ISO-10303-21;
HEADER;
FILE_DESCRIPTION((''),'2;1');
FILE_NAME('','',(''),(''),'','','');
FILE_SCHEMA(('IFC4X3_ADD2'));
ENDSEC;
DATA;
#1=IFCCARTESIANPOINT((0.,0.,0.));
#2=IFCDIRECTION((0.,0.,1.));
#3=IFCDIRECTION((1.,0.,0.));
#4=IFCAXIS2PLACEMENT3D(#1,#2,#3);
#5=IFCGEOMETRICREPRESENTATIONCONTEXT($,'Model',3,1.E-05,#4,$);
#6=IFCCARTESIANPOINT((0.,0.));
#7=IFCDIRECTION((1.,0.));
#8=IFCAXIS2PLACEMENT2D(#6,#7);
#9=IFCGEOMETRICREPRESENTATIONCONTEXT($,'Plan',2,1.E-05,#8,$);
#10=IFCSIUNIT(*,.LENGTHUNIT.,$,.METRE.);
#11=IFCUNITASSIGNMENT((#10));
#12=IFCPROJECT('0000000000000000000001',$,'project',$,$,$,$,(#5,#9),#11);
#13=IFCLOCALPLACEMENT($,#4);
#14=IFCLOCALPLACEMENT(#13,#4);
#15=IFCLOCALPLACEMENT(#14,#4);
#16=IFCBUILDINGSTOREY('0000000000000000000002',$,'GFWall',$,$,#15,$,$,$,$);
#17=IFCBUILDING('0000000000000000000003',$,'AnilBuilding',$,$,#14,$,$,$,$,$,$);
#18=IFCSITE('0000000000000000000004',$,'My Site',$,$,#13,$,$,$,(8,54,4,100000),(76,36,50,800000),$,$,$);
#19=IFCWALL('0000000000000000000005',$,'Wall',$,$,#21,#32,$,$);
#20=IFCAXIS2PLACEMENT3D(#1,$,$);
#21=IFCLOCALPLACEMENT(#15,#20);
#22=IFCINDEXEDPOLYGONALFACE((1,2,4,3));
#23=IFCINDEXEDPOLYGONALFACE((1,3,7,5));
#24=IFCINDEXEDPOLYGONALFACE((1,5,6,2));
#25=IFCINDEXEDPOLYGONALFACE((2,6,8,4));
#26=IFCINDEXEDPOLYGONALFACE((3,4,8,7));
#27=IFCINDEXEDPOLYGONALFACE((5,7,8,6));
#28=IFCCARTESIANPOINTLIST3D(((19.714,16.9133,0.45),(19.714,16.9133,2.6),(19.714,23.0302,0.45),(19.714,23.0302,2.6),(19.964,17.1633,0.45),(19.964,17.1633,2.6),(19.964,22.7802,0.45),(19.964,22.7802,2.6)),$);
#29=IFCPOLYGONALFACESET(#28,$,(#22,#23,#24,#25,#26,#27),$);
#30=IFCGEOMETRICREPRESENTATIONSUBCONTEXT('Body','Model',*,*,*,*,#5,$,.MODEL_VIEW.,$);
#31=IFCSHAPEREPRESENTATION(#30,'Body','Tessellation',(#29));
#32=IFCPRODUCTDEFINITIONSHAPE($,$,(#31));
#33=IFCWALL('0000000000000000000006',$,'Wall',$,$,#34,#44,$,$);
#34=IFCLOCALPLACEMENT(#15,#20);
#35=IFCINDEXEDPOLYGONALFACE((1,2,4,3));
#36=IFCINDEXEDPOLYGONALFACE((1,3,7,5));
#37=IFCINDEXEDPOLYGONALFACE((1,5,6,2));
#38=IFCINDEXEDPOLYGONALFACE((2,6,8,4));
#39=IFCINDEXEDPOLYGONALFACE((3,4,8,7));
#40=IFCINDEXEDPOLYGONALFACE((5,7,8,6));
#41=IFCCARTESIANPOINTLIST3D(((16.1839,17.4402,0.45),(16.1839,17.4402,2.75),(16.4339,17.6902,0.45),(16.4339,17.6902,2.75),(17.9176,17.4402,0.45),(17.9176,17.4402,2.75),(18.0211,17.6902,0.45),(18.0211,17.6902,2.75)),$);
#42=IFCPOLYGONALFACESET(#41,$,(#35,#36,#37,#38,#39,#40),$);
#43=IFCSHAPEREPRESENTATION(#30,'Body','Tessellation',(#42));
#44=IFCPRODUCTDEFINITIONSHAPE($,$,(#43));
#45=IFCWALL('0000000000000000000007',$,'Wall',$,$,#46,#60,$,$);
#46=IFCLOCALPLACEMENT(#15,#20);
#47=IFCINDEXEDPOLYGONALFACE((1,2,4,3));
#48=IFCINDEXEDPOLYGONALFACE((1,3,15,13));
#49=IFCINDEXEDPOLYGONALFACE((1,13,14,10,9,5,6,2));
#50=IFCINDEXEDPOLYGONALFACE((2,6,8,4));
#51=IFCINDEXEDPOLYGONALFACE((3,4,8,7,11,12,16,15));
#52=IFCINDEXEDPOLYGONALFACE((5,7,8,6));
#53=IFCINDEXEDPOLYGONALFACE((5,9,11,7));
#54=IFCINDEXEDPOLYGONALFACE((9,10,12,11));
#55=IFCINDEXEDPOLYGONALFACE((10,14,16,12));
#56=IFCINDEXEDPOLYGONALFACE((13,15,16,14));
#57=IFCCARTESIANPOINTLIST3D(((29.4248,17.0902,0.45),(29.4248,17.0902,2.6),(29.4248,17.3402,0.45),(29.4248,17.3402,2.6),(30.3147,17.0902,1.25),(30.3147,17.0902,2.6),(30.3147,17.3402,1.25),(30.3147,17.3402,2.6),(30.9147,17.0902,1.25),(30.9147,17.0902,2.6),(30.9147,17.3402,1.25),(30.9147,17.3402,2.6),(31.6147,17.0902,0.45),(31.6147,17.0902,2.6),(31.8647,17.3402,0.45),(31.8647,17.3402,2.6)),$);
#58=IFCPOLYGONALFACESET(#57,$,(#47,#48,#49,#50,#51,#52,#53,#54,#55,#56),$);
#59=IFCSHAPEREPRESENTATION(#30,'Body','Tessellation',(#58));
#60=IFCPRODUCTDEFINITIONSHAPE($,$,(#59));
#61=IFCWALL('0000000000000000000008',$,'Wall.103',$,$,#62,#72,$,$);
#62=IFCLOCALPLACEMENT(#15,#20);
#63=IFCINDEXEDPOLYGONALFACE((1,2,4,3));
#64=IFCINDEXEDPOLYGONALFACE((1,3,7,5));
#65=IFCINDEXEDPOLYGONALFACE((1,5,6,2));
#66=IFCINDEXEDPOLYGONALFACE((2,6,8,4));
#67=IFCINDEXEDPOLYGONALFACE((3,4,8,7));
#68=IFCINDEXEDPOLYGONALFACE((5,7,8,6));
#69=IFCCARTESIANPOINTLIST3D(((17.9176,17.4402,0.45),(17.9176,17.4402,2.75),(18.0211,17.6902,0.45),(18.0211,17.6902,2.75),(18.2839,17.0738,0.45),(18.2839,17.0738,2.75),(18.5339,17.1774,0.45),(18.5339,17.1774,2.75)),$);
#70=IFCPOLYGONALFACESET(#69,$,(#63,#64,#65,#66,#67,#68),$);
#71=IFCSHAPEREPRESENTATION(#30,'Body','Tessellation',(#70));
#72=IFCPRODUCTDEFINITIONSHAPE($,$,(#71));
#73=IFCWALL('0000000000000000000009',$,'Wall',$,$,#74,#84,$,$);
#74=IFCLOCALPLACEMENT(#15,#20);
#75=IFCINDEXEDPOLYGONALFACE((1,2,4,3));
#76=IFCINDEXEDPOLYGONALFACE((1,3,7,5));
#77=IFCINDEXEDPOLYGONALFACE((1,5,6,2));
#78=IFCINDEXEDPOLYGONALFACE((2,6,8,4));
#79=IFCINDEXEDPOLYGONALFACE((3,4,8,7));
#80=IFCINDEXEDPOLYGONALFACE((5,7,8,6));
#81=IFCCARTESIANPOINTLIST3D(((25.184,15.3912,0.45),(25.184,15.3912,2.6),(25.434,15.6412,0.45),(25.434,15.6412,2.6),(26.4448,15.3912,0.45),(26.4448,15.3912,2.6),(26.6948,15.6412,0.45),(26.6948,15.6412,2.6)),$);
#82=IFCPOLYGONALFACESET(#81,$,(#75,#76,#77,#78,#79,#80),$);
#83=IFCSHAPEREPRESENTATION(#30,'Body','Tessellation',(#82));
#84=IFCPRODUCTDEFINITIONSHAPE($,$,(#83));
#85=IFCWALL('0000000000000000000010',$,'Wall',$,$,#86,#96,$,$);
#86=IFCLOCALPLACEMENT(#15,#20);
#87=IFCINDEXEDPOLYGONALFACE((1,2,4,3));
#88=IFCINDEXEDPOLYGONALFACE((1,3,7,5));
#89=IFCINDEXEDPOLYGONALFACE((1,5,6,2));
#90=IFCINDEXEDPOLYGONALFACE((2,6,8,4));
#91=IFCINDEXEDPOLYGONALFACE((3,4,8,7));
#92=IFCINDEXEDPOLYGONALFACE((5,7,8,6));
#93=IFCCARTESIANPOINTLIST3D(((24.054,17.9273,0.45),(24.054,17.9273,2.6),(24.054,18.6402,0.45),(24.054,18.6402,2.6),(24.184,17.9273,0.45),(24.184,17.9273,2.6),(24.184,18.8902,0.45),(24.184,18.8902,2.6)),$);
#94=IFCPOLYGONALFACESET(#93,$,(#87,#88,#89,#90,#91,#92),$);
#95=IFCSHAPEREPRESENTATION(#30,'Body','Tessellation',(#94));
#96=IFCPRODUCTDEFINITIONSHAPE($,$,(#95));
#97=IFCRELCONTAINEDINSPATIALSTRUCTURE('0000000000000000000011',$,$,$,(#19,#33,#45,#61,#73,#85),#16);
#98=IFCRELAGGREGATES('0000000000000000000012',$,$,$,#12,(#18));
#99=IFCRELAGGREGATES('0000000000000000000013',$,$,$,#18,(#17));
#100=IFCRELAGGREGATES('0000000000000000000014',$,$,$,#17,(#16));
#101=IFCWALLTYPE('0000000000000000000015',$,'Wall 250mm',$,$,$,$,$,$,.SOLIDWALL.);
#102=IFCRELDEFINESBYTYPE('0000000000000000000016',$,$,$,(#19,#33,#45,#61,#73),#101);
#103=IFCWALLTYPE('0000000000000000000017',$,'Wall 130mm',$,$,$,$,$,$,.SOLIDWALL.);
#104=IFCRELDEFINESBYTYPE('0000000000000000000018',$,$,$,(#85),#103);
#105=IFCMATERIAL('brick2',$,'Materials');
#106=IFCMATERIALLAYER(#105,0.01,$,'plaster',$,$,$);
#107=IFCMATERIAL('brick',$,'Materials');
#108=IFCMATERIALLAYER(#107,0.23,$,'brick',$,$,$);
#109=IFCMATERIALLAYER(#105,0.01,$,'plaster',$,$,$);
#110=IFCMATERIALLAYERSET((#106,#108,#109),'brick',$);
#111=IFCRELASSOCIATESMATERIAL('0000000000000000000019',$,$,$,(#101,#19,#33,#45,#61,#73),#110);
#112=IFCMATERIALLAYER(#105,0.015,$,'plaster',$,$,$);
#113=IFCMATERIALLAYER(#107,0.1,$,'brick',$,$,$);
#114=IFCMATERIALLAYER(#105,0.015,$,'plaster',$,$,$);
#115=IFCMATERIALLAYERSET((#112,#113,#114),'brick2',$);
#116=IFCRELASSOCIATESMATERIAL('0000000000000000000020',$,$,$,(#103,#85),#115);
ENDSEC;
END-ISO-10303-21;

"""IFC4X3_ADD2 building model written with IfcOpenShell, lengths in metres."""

from ifc_helpers import new_model, si_unit, frame, origin_with_axes, origin_2d_with_axis, place, context, subcontext, project, spatial, line, indexed_curve, outline, extrude, source, transform, mapped, material, layer, layer_set, layer_usage, type_object, element, save


model = new_model("IFC4X3_ADD2")

# Units and contexts
model_context = context("Model", 3, precision=1e-05, world=origin_with_axes())
plan_context = context("Plan", 2, precision=1e-05, world=origin_2d_with_axis())
body_context = subcontext(model_context, "Body", "Model", "MODEL_VIEW")
ifc_project = project(units=[si_unit("LENGTHUNIT", "METRE")], contexts=[model_context, plan_context])

# Site, building, storey
site_placement = place(None, origin_with_axes())
site = spatial("IfcSite", under=ifc_project, at=site_placement, Name="My Site", RefLatitude=(8, 54, 4, 100000), RefLongitude=(76, 36, 50, 800000))
building_placement = place(site_placement, origin_with_axes())
building = spatial("IfcBuilding", under=site, at=building_placement, Name="AnilBuilding")
storey_placement = place(building_placement, origin_with_axes())
storey = spatial("IfcBuildingStorey", under=building, at=storey_placement, Name="GFWall")

# Walls
ifc_material_1 = material(Name="brick2", Category="Materials")
ifc_layer_1 = layer(ifc_material_1, 0.01, Name="plaster")
ifc_material_2 = material(Name="brick", Category="Materials")
ifc_layer_2 = layer(ifc_material_2, 0.23, Name="brick")
ifc_layer_3 = layer(ifc_material_1, 0.01, Name="plaster")
ifc_layer_set_1 = layer_set([ifc_layer_1, ifc_layer_2, ifc_layer_3], Name="brick")
ifc_layer_usage_1 = layer_usage(ifc_layer_set_1, "AXIS2", "NEGATIVE", 0.0)
wall_type_1 = type_object("IfcWallType", Name="Wall 250mm", PredefinedType="SOLIDWALL", material=ifc_layer_set_1)
wall_1_placement = place(storey_placement, frame((19.714, 17.1633, 0.45), z_axis=(0.0, 0.0, 1.0), x_axis=(0.000001, 1.0, 0.0)))
element("IfcWall", 1, at=wall_1_placement, inside=storey, type_object=wall_type_1, material=ifc_layer_usage_1, Name="Wall", context=body_context, shape_type="SweptSolid", body=[
    extrude(outline(indexed_curve([(0.0, -0.25), (-0.25, 0.0), (5.8669, 0.0), (5.6169, -0.25)], segments=[line(1, 2, 3, 4, 1)])), origin_with_axes(), (0.0, 0.0, 1.0), 2.15),
])
ifc_layer_usage_2 = layer_usage(ifc_layer_set_1, "AXIS2", "NEGATIVE", 0.0)
wall_2_placement = place(storey_placement, frame((17.9176, 17.4402, 0.45), z_axis=(0.0, 0.0, 1.0), x_axis=(-1.0, 0.0, 0.0)))
element("IfcWall", 2, at=wall_2_placement, inside=storey, type_object=wall_type_1, material=ifc_layer_usage_2, Name="Wall", context=body_context, shape_type="SweptSolid", body=[
    extrude(outline(indexed_curve([(-0.1036, -0.25), (0.0, 0.0), (1.7336, 0.0), (1.4836, -0.25)], segments=[line(1, 2, 3, 4, 1)])), origin_with_axes(), (0.0, 0.0, 1.0), 2.3),
])

# Wall, opening
ifc_layer_usage_3 = layer_usage(ifc_layer_set_1, "AXIS2", "POSITIVE", 0.0)
wall_3_placement = place(storey_placement, frame((31.8647, 17.3402, 0.45), z_axis=(0.0, 0.0, 1.0), x_axis=(-1.0, 0.0, 0.0)))
wall_3 = element("IfcWall", 3, at=wall_3_placement, inside=storey, type_object=wall_type_1, material=ifc_layer_usage_3, Name="Wall", context=body_context, shape_type="SweptSolid", body=[
    extrude(outline(indexed_curve([(0.0, 0.0), (0.25, 0.25), (2.44, 0.25), (2.44, 0.0)], segments=[line(1, 2, 3, 4, 1)])), origin_with_axes(), (0.0, 0.0, 1.0), 2.15),
])
shared_shape_1 = source(origin_with_axes(), body_context, "Body", "SweptSolid", [
    extrude(outline(indexed_curve([(0.0, 0.0), (0.6, 0.0), (0.6, 1.5), (0.0, 1.5)], segments=[line(1, 2, 3, 4, 1)])), frame((0.0, -0.6, 0.0), z_axis=(0.0, -1.0, 0.0), x_axis=(1.0, 0.0, 0.0)), (0.0, 0.0, -1.0), 1.2),
])
opening_1_placement = place(wall_3_placement, frame((1.55, 0.07, 0.8), z_axis=(0.0, 0.0, 1.0), x_axis=(-1.0, 0.0, 0.0)))
element("IfcOpeningElement", 4, at=opening_1_placement, cuts=wall_3, PredefinedType="OPENING", context=body_context, shape_type="MappedRepresentation", body=[
    mapped(shared_shape_1, transform((0.0, 0.0, 0.0), x_axis=(1.0, 0.0, 0.0), y_axis=(0.0, 1.0, 0.0), z_axis=(0.0, 0.0, 1.0), scale=1.0)),
])

# Walls
ifc_layer_usage_4 = layer_usage(ifc_layer_set_1, "AXIS2", "NEGATIVE", 0.0)
wall_4_placement = place(storey_placement, frame((18.2839, 17.0738, 0.45), z_axis=(0.0, 0.0, 1.0), x_axis=(-0.707107, 0.707107, 0.0)))
element("IfcWall", 5, at=wall_4_placement, inside=storey, type_object=wall_type_1, material=ifc_layer_usage_4, Name="Wall.103", context=body_context, shape_type="SweptSolid", body=[
    extrude(outline(indexed_curve([(-0.1036, -0.25), (0.0, 0.0), (0.5181, 0.0), (0.6217, -0.25)], segments=[line(1, 2, 3, 4, 1)])), origin_with_axes(), (0.0, 0.0, 1.0), 2.3),
])
ifc_layer_usage_5 = layer_usage(ifc_layer_set_1, "AXIS2", "POSITIVE", 0.0)
wall_5_placement = place(storey_placement, frame((26.6948, 15.6412, 0.45), z_axis=(0.0, 0.0, 1.0), x_axis=(-1.0, 0.0, 0.0)))
element("IfcWall", 6, at=wall_5_placement, inside=storey, type_object=wall_type_1, material=ifc_layer_usage_5, Name="Wall", context=body_context, shape_type="SweptSolid", body=[
    extrude(outline(indexed_curve([(0.0, 0.0), (0.25, 0.25), (1.5108, 0.25), (1.2608, 0.0)], segments=[line(1, 2, 3, 4, 1)])), origin_with_axes(), (0.0, 0.0, 1.0), 2.15),
])
ifc_layer_4 = layer(ifc_material_1, 0.015, Name="plaster")
ifc_layer_5 = layer(ifc_material_2, 0.1, Name="brick")
ifc_layer_6 = layer(ifc_material_1, 0.015, Name="plaster")
ifc_layer_set_2 = layer_set([ifc_layer_4, ifc_layer_5, ifc_layer_6], Name="brick2")
ifc_layer_usage_6 = layer_usage(ifc_layer_set_2, "AXIS2", "POSITIVE", 0.0)
wall_type_2 = type_object("IfcWallType", Name="Wall 130mm", PredefinedType="SOLIDWALL", material=ifc_layer_set_2)
wall_6_placement = place(storey_placement, frame((24.184, 17.9273, 0.45), z_axis=(0.0, 0.0, 1.0), x_axis=(0.000001, 1.0, 0.0)))
element("IfcWall", 7, at=wall_6_placement, inside=storey, type_object=wall_type_2, material=ifc_layer_usage_6, Name="Wall", context=body_context, shape_type="SweptSolid", body=[
    extrude(outline(indexed_curve([(0.0, 0.0), (0.0, 0.13), (0.7129, 0.13), (0.9629, 0.0)], segments=[line(1, 2, 3, 4, 1)])), origin_with_axes(), (0.0, 0.0, 1.0), 2.15),
])

save(model, "model.ifc")
